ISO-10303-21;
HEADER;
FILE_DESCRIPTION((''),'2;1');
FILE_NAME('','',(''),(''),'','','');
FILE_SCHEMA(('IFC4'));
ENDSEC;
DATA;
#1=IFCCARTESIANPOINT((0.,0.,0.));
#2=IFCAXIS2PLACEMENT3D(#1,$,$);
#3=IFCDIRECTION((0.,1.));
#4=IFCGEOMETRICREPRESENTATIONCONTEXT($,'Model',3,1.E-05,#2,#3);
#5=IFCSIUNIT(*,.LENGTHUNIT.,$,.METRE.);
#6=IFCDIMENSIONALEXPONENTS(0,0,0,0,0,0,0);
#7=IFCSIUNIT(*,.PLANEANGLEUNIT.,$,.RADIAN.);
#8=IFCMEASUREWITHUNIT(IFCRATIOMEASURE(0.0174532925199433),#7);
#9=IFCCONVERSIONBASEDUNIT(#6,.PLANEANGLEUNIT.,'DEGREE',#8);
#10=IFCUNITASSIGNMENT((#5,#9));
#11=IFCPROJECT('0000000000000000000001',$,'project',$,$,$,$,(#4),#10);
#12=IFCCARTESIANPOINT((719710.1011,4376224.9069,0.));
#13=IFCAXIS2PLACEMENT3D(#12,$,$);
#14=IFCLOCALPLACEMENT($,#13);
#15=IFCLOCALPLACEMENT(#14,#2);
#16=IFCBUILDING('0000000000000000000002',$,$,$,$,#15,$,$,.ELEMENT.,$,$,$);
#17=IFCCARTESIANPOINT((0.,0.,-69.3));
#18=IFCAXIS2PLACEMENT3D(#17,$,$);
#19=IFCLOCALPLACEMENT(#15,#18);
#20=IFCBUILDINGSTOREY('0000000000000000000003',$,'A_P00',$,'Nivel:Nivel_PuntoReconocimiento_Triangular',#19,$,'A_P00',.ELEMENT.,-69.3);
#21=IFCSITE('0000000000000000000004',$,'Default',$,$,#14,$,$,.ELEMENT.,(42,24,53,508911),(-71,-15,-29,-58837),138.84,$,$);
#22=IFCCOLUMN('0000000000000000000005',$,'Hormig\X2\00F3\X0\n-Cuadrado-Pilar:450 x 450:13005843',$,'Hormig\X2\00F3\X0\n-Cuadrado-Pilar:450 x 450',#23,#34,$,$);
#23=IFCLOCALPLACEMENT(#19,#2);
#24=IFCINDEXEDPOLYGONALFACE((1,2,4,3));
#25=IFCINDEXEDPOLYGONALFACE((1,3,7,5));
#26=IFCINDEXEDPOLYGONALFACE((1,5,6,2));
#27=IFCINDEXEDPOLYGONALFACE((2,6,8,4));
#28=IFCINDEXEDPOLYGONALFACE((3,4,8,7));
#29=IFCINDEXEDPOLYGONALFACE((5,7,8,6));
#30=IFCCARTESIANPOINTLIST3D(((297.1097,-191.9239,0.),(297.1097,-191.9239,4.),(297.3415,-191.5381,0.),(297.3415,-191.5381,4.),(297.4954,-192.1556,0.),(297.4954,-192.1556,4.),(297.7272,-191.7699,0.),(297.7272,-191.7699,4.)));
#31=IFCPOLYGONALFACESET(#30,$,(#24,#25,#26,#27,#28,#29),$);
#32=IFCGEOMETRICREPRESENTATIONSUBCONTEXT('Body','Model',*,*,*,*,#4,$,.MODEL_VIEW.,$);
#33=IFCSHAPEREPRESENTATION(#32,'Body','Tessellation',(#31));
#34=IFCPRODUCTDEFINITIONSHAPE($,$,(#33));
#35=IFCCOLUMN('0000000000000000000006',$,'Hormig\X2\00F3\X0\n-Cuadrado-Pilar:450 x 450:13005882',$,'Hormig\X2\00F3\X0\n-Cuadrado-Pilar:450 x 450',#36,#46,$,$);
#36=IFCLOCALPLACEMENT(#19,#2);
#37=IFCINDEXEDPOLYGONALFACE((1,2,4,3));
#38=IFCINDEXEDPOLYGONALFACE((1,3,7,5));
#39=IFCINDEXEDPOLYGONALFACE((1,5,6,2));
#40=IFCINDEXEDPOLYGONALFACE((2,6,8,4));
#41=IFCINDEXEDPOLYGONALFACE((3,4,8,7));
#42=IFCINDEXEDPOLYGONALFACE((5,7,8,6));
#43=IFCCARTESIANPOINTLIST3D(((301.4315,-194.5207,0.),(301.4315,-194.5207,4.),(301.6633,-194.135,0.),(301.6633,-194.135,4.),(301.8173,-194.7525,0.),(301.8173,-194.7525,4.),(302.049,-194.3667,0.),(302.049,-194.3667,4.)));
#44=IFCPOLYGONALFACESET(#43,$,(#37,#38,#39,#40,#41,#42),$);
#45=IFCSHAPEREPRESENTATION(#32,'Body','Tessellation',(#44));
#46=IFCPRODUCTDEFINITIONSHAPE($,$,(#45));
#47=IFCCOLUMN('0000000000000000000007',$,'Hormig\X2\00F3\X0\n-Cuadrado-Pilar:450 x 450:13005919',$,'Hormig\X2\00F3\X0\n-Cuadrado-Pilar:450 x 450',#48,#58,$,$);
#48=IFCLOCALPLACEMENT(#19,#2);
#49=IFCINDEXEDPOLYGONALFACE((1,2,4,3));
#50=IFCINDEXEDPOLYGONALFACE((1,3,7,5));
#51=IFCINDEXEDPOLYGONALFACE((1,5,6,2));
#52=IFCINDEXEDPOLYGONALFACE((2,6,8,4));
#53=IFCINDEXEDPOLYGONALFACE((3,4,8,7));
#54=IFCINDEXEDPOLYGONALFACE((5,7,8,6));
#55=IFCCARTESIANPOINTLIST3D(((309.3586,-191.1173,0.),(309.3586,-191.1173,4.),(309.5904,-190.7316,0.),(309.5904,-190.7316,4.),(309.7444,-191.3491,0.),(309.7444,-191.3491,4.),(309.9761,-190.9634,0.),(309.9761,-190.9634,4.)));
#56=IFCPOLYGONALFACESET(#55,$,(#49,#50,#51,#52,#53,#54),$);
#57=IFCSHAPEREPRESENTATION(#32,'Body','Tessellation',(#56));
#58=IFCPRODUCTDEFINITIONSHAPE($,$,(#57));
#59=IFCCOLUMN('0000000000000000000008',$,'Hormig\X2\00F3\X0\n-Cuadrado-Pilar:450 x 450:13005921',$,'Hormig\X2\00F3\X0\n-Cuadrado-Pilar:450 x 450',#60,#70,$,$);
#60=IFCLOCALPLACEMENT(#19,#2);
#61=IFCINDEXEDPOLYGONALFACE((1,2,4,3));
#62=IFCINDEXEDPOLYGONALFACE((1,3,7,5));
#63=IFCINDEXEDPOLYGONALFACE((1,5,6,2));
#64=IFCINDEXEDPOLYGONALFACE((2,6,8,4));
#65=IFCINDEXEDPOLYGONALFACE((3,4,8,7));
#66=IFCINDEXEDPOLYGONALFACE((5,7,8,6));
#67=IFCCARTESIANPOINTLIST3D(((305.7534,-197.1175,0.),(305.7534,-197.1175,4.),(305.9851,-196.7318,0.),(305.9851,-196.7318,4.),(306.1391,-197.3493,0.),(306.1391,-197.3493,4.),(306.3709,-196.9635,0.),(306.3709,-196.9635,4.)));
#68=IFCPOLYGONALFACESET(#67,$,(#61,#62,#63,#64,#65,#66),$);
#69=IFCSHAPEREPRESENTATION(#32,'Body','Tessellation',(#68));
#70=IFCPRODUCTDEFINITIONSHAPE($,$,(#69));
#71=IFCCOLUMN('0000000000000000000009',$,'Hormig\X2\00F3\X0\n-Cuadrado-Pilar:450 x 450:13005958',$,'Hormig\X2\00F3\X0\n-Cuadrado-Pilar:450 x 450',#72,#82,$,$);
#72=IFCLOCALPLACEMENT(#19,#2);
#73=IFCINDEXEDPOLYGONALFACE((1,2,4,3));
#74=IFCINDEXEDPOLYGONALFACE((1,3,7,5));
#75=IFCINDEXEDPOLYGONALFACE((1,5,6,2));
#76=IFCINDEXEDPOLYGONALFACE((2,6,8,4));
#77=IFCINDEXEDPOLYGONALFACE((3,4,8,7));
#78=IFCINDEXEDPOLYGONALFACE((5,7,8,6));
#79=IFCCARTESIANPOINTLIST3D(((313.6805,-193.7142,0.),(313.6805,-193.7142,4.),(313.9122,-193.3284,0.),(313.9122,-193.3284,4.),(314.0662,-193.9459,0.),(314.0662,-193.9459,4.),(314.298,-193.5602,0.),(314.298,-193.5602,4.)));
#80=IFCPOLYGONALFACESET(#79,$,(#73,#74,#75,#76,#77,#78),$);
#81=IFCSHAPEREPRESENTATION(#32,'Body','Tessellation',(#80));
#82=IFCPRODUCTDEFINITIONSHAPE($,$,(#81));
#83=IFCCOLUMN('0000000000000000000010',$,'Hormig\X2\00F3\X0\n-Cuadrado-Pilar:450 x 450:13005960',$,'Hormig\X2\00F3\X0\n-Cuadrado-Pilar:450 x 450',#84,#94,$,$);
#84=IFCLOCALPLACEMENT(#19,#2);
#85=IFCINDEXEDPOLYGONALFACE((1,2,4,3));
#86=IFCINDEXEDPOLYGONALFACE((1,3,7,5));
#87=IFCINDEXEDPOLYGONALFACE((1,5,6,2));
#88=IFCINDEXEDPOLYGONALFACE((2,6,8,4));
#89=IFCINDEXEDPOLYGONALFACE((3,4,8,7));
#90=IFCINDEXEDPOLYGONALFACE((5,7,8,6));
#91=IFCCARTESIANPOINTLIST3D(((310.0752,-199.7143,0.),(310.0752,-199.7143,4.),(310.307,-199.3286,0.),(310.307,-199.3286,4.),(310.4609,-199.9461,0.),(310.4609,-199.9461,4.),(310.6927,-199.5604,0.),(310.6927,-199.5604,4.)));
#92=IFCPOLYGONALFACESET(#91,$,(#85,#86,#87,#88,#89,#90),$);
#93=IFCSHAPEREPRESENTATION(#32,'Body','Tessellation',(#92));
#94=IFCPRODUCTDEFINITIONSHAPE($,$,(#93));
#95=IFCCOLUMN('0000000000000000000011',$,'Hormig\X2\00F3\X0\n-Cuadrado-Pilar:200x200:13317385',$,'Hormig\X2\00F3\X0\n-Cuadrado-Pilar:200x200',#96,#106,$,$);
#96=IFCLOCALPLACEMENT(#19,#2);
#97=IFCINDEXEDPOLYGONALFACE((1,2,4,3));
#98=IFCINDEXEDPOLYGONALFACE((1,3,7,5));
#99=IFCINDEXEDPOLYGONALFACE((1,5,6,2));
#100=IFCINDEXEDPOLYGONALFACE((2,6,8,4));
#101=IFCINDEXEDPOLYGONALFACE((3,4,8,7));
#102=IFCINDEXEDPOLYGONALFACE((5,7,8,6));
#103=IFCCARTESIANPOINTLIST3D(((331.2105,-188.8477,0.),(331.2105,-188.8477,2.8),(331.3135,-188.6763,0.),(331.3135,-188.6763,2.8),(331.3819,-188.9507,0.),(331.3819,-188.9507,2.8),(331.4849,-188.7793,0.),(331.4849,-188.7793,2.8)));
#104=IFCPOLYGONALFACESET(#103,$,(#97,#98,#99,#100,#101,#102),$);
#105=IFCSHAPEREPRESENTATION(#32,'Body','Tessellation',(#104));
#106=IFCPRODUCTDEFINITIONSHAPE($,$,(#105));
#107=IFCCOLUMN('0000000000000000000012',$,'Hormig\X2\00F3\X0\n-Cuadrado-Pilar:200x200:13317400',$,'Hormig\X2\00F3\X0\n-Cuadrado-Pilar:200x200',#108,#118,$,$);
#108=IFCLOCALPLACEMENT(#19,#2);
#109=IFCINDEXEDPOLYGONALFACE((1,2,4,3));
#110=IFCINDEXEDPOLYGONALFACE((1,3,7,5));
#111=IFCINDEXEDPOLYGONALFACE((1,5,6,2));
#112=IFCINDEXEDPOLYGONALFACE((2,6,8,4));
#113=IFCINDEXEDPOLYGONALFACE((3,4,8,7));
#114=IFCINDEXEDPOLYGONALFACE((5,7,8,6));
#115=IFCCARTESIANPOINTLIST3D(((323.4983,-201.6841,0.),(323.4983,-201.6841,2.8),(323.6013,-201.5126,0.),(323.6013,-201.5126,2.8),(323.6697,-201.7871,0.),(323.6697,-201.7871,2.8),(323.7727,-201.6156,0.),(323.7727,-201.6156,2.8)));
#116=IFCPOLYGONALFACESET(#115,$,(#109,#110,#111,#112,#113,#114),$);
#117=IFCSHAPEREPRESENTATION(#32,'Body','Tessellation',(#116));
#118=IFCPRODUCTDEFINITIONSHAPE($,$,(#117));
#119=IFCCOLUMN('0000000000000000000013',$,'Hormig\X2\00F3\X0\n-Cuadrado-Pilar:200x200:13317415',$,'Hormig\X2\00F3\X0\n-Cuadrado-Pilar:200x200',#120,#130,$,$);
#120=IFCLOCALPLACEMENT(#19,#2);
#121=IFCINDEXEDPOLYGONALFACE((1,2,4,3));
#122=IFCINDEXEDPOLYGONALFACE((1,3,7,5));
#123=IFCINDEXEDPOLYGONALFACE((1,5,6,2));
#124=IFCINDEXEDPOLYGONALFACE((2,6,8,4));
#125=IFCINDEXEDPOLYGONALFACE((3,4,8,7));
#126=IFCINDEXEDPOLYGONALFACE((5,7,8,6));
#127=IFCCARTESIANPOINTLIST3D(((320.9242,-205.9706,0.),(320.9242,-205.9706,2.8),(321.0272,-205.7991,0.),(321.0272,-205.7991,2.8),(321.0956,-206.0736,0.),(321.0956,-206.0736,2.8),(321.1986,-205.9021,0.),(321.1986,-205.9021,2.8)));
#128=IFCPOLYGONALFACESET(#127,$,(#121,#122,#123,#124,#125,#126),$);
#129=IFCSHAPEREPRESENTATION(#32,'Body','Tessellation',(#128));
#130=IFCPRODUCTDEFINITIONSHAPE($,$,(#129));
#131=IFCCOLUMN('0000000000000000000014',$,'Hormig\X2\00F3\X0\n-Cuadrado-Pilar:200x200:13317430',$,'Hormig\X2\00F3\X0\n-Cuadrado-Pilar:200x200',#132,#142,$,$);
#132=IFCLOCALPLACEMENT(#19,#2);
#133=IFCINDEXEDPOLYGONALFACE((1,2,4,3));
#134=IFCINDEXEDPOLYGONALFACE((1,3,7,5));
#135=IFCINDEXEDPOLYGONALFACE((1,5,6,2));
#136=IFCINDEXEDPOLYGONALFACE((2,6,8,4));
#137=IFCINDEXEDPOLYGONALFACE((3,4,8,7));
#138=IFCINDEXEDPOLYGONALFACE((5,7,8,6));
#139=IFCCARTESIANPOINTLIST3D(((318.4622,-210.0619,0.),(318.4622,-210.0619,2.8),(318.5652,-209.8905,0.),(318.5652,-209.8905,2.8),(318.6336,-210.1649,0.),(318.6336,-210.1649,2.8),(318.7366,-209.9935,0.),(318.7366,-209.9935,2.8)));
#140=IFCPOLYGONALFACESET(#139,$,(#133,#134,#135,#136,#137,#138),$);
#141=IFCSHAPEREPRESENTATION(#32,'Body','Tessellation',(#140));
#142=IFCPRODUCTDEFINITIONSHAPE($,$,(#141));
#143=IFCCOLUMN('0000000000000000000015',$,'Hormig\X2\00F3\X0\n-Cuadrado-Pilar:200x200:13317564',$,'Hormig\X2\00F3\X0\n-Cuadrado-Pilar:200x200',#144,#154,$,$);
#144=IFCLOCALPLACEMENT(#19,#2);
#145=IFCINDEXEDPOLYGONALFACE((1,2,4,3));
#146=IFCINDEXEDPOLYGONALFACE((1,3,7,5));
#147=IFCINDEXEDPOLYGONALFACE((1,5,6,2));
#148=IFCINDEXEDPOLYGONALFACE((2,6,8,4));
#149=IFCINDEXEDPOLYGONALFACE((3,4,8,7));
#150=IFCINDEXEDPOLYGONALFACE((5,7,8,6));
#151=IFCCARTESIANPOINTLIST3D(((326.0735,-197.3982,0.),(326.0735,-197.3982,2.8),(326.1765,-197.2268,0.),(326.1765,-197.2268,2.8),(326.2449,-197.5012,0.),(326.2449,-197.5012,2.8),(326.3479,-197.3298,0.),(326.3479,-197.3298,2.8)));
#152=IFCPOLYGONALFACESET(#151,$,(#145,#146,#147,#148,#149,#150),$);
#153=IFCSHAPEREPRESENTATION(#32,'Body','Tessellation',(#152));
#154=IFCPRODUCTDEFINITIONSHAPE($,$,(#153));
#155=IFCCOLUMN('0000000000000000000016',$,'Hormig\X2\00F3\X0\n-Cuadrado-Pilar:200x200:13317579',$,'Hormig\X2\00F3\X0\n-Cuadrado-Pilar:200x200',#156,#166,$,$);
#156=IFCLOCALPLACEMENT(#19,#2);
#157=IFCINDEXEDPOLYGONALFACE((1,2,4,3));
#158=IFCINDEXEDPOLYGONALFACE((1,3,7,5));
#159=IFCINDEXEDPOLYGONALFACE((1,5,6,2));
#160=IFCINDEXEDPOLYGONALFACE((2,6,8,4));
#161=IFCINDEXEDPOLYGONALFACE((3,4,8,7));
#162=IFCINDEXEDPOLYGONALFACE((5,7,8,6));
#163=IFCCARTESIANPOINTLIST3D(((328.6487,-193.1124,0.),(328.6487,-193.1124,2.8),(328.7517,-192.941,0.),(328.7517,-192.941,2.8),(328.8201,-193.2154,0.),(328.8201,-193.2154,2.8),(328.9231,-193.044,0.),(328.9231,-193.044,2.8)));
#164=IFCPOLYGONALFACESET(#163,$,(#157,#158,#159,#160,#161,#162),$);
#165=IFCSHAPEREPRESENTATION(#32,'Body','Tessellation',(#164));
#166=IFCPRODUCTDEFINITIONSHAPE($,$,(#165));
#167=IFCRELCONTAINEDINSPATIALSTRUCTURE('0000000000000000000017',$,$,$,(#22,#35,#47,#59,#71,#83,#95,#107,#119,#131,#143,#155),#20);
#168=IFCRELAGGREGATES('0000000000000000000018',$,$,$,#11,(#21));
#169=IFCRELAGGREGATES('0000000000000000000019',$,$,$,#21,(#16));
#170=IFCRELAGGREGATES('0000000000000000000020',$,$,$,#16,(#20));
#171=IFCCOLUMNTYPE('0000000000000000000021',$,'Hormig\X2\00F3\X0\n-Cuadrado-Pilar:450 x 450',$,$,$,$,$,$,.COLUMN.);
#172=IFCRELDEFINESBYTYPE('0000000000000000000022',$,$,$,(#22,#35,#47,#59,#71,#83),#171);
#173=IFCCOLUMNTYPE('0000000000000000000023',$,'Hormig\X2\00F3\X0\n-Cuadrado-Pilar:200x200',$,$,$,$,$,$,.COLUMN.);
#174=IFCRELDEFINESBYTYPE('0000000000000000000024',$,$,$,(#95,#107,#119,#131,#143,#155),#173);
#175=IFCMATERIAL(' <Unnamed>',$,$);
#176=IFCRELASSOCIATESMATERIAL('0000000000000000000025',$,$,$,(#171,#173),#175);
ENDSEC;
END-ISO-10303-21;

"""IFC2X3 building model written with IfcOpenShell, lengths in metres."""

from ifc_helpers import new_model, entity, si_unit, converted_unit, direction, frame, origin, origin_2d_with_axis, place, context, subcontext, project, spatial, rectangle, extrude, source, transform, mapped, material, type_object, type_shapes, element, save


model = new_model("IFC2X3")

# Units and contexts
model_context = context("Model", 3, precision=1e-05, world=origin(), true_north=direction((0.0, 1.0)))
body_context = subcontext(model_context, "Body", "Model", "MODEL_VIEW")
ifc_project = project(units=[si_unit("LENGTHUNIT", "METRE"), converted_unit("PLANEANGLEUNIT", "DEGREE", entity("IfcRatioMeasure", 0.0174532925199433), si_unit("PLANEANGLEUNIT", "RADIAN"), dimensions=[0, 0, 0, 0, 0, 0, 0])], contexts=[model_context])

# Site, building, storey
site_placement = place(None, frame((719710.1011, 4376224.9069, 0.0)))
site = spatial("IfcSite", under=ifc_project, at=site_placement, Name="Default", CompositionType="ELEMENT", RefLatitude=(42, 24, 53, 508911), RefLongitude=(-71, -15, -29, -58837), RefElevation=138.84)
building_placement = place(site_placement, origin())
building = spatial("IfcBuilding", under=site, at=building_placement, CompositionType="ELEMENT")
storey_placement = place(building_placement, frame((0.0, 0.0, -69.3)))
storey = spatial("IfcBuildingStorey", under=building, at=storey_placement, Name="A_P00", ObjectType="Nivel:Nivel_PuntoReconocimiento_Triangular", LongName="A_P00", CompositionType="ELEMENT", Elevation=-69.3)

# Columns
ifc_material = material(Name=" <Unnamed>")
column_type_1 = type_object("IfcColumnType", Name="Hormigón-Cuadrado-Pilar:450 x 450", PredefinedType="COLUMN", material=ifc_material)
shared_shape_1 = source(origin(), body_context, "Body", "SweptSolid", [
    extrude(rectangle(XDim=0.45, YDim=0.45, at=origin_2d_with_axis()), frame((0.0, 0.0, -69.3), z_axis=(0.0, 0.0, 1.0), x_axis=(0.0, -1.0, 0.0)), (0.0, 0.0, 1.0), 4.0),
])
type_shapes(column_type_1, [shared_shape_1])
for number, where, z_axis, x_axis, name in (
    (1, (297.4184, -191.8469, 69.3), (0.0, 0.0, 1.0), (0.857167, -0.515038, 0.0), "Hormigón-Cuadrado-Pilar:450 x 450:13005843"),
    (2, (301.7403, -194.4437, 69.3), (0.0, 0.0, 1.0), (0.857167, -0.515038, 0.0), "Hormigón-Cuadrado-Pilar:450 x 450:13005882"),
    (3, (309.6674, -191.0404, 69.3), (0.0, 0.0, 1.0), (0.857167, -0.515038, 0.0), "Hormigón-Cuadrado-Pilar:450 x 450:13005919"),
    (4, (306.0621, -197.0405, 69.3), (0.0, 0.0, 1.0), (0.857167, -0.515038, 0.0), "Hormigón-Cuadrado-Pilar:450 x 450:13005921"),
    (5, (313.9892, -193.6372, 69.3), (0.0, 0.0, 1.0), (0.857167, -0.515038, 0.0), "Hormigón-Cuadrado-Pilar:450 x 450:13005958"),
    (6, (310.384, -199.6373, 69.3), (0.0, 0.0, 1.0), (0.857167, -0.515038, 0.0), "Hormigón-Cuadrado-Pilar:450 x 450:13005960"),
):
    element("IfcColumn", number, at=place(storey_placement, frame(where, z_axis=z_axis, x_axis=x_axis)), inside=storey, type_object=column_type_1, Name=name, ObjectType="Hormigón-Cuadrado-Pilar:450 x 450", context=body_context, shape_type="MappedRepresentation", body=[
        mapped(shared_shape_1, transform((0.0, 0.0, 0.0), scale=1.0)),
    ])
column_type_2 = type_object("IfcColumnType", Name="Hormigón-Cuadrado-Pilar:200x200", PredefinedType="COLUMN", material=ifc_material)
shared_shape_2 = source(origin(), body_context, "Body", "SweptSolid", [
    extrude(rectangle(XDim=0.2, YDim=0.2, at=origin_2d_with_axis()), frame((0.0, 0.0, -69.3), z_axis=(0.0, 0.0, 1.0), x_axis=(0.0, -1.0, 0.0)), (0.0, 0.0, 1.0), 2.8),
])
type_shapes(column_type_2, [shared_shape_2])
for number, where, z_axis, x_axis, name in (
    (7, (331.3477, -188.8135, 69.3), (0.0, 0.0, 1.0), (0.857167, -0.515038, 0.0), "Hormigón-Cuadrado-Pilar:200x200:13317385"),
    (8, (323.6355, -201.6499, 69.3), (0.0, 0.0, 1.0), (0.857167, -0.515038, 0.0), "Hormigón-Cuadrado-Pilar:200x200:13317400"),
    (9, (321.0614, -205.9363, 69.3), (0.0, 0.0, 1.0), (0.857167, -0.515038, 0.0), "Hormigón-Cuadrado-Pilar:200x200:13317415"),
    (10, (318.5994, -210.0277, 69.3), (0.0, 0.0, 1.0), (0.857167, -0.515038, 0.0), "Hormigón-Cuadrado-Pilar:200x200:13317430"),
    (11, (326.2107, -197.364, 69.3), (0.0, 0.0, 1.0), (0.857167, -0.515038, 0.0), "Hormigón-Cuadrado-Pilar:200x200:13317564"),
    (12, (328.7859, -193.0782, 69.3), (0.0, 0.0, 1.0), (0.857167, -0.515038, 0.0), "Hormigón-Cuadrado-Pilar:200x200:13317579"),
):
    element("IfcColumn", number, at=place(storey_placement, frame(where, z_axis=z_axis, x_axis=x_axis)), inside=storey, type_object=column_type_2, Name=name, ObjectType="Hormigón-Cuadrado-Pilar:200x200", context=body_context, shape_type="MappedRepresentation", body=[
        mapped(shared_shape_2, transform((0.0, 0.0, 0.0), scale=1.0)),
    ])

save(model, "model.ifc")
